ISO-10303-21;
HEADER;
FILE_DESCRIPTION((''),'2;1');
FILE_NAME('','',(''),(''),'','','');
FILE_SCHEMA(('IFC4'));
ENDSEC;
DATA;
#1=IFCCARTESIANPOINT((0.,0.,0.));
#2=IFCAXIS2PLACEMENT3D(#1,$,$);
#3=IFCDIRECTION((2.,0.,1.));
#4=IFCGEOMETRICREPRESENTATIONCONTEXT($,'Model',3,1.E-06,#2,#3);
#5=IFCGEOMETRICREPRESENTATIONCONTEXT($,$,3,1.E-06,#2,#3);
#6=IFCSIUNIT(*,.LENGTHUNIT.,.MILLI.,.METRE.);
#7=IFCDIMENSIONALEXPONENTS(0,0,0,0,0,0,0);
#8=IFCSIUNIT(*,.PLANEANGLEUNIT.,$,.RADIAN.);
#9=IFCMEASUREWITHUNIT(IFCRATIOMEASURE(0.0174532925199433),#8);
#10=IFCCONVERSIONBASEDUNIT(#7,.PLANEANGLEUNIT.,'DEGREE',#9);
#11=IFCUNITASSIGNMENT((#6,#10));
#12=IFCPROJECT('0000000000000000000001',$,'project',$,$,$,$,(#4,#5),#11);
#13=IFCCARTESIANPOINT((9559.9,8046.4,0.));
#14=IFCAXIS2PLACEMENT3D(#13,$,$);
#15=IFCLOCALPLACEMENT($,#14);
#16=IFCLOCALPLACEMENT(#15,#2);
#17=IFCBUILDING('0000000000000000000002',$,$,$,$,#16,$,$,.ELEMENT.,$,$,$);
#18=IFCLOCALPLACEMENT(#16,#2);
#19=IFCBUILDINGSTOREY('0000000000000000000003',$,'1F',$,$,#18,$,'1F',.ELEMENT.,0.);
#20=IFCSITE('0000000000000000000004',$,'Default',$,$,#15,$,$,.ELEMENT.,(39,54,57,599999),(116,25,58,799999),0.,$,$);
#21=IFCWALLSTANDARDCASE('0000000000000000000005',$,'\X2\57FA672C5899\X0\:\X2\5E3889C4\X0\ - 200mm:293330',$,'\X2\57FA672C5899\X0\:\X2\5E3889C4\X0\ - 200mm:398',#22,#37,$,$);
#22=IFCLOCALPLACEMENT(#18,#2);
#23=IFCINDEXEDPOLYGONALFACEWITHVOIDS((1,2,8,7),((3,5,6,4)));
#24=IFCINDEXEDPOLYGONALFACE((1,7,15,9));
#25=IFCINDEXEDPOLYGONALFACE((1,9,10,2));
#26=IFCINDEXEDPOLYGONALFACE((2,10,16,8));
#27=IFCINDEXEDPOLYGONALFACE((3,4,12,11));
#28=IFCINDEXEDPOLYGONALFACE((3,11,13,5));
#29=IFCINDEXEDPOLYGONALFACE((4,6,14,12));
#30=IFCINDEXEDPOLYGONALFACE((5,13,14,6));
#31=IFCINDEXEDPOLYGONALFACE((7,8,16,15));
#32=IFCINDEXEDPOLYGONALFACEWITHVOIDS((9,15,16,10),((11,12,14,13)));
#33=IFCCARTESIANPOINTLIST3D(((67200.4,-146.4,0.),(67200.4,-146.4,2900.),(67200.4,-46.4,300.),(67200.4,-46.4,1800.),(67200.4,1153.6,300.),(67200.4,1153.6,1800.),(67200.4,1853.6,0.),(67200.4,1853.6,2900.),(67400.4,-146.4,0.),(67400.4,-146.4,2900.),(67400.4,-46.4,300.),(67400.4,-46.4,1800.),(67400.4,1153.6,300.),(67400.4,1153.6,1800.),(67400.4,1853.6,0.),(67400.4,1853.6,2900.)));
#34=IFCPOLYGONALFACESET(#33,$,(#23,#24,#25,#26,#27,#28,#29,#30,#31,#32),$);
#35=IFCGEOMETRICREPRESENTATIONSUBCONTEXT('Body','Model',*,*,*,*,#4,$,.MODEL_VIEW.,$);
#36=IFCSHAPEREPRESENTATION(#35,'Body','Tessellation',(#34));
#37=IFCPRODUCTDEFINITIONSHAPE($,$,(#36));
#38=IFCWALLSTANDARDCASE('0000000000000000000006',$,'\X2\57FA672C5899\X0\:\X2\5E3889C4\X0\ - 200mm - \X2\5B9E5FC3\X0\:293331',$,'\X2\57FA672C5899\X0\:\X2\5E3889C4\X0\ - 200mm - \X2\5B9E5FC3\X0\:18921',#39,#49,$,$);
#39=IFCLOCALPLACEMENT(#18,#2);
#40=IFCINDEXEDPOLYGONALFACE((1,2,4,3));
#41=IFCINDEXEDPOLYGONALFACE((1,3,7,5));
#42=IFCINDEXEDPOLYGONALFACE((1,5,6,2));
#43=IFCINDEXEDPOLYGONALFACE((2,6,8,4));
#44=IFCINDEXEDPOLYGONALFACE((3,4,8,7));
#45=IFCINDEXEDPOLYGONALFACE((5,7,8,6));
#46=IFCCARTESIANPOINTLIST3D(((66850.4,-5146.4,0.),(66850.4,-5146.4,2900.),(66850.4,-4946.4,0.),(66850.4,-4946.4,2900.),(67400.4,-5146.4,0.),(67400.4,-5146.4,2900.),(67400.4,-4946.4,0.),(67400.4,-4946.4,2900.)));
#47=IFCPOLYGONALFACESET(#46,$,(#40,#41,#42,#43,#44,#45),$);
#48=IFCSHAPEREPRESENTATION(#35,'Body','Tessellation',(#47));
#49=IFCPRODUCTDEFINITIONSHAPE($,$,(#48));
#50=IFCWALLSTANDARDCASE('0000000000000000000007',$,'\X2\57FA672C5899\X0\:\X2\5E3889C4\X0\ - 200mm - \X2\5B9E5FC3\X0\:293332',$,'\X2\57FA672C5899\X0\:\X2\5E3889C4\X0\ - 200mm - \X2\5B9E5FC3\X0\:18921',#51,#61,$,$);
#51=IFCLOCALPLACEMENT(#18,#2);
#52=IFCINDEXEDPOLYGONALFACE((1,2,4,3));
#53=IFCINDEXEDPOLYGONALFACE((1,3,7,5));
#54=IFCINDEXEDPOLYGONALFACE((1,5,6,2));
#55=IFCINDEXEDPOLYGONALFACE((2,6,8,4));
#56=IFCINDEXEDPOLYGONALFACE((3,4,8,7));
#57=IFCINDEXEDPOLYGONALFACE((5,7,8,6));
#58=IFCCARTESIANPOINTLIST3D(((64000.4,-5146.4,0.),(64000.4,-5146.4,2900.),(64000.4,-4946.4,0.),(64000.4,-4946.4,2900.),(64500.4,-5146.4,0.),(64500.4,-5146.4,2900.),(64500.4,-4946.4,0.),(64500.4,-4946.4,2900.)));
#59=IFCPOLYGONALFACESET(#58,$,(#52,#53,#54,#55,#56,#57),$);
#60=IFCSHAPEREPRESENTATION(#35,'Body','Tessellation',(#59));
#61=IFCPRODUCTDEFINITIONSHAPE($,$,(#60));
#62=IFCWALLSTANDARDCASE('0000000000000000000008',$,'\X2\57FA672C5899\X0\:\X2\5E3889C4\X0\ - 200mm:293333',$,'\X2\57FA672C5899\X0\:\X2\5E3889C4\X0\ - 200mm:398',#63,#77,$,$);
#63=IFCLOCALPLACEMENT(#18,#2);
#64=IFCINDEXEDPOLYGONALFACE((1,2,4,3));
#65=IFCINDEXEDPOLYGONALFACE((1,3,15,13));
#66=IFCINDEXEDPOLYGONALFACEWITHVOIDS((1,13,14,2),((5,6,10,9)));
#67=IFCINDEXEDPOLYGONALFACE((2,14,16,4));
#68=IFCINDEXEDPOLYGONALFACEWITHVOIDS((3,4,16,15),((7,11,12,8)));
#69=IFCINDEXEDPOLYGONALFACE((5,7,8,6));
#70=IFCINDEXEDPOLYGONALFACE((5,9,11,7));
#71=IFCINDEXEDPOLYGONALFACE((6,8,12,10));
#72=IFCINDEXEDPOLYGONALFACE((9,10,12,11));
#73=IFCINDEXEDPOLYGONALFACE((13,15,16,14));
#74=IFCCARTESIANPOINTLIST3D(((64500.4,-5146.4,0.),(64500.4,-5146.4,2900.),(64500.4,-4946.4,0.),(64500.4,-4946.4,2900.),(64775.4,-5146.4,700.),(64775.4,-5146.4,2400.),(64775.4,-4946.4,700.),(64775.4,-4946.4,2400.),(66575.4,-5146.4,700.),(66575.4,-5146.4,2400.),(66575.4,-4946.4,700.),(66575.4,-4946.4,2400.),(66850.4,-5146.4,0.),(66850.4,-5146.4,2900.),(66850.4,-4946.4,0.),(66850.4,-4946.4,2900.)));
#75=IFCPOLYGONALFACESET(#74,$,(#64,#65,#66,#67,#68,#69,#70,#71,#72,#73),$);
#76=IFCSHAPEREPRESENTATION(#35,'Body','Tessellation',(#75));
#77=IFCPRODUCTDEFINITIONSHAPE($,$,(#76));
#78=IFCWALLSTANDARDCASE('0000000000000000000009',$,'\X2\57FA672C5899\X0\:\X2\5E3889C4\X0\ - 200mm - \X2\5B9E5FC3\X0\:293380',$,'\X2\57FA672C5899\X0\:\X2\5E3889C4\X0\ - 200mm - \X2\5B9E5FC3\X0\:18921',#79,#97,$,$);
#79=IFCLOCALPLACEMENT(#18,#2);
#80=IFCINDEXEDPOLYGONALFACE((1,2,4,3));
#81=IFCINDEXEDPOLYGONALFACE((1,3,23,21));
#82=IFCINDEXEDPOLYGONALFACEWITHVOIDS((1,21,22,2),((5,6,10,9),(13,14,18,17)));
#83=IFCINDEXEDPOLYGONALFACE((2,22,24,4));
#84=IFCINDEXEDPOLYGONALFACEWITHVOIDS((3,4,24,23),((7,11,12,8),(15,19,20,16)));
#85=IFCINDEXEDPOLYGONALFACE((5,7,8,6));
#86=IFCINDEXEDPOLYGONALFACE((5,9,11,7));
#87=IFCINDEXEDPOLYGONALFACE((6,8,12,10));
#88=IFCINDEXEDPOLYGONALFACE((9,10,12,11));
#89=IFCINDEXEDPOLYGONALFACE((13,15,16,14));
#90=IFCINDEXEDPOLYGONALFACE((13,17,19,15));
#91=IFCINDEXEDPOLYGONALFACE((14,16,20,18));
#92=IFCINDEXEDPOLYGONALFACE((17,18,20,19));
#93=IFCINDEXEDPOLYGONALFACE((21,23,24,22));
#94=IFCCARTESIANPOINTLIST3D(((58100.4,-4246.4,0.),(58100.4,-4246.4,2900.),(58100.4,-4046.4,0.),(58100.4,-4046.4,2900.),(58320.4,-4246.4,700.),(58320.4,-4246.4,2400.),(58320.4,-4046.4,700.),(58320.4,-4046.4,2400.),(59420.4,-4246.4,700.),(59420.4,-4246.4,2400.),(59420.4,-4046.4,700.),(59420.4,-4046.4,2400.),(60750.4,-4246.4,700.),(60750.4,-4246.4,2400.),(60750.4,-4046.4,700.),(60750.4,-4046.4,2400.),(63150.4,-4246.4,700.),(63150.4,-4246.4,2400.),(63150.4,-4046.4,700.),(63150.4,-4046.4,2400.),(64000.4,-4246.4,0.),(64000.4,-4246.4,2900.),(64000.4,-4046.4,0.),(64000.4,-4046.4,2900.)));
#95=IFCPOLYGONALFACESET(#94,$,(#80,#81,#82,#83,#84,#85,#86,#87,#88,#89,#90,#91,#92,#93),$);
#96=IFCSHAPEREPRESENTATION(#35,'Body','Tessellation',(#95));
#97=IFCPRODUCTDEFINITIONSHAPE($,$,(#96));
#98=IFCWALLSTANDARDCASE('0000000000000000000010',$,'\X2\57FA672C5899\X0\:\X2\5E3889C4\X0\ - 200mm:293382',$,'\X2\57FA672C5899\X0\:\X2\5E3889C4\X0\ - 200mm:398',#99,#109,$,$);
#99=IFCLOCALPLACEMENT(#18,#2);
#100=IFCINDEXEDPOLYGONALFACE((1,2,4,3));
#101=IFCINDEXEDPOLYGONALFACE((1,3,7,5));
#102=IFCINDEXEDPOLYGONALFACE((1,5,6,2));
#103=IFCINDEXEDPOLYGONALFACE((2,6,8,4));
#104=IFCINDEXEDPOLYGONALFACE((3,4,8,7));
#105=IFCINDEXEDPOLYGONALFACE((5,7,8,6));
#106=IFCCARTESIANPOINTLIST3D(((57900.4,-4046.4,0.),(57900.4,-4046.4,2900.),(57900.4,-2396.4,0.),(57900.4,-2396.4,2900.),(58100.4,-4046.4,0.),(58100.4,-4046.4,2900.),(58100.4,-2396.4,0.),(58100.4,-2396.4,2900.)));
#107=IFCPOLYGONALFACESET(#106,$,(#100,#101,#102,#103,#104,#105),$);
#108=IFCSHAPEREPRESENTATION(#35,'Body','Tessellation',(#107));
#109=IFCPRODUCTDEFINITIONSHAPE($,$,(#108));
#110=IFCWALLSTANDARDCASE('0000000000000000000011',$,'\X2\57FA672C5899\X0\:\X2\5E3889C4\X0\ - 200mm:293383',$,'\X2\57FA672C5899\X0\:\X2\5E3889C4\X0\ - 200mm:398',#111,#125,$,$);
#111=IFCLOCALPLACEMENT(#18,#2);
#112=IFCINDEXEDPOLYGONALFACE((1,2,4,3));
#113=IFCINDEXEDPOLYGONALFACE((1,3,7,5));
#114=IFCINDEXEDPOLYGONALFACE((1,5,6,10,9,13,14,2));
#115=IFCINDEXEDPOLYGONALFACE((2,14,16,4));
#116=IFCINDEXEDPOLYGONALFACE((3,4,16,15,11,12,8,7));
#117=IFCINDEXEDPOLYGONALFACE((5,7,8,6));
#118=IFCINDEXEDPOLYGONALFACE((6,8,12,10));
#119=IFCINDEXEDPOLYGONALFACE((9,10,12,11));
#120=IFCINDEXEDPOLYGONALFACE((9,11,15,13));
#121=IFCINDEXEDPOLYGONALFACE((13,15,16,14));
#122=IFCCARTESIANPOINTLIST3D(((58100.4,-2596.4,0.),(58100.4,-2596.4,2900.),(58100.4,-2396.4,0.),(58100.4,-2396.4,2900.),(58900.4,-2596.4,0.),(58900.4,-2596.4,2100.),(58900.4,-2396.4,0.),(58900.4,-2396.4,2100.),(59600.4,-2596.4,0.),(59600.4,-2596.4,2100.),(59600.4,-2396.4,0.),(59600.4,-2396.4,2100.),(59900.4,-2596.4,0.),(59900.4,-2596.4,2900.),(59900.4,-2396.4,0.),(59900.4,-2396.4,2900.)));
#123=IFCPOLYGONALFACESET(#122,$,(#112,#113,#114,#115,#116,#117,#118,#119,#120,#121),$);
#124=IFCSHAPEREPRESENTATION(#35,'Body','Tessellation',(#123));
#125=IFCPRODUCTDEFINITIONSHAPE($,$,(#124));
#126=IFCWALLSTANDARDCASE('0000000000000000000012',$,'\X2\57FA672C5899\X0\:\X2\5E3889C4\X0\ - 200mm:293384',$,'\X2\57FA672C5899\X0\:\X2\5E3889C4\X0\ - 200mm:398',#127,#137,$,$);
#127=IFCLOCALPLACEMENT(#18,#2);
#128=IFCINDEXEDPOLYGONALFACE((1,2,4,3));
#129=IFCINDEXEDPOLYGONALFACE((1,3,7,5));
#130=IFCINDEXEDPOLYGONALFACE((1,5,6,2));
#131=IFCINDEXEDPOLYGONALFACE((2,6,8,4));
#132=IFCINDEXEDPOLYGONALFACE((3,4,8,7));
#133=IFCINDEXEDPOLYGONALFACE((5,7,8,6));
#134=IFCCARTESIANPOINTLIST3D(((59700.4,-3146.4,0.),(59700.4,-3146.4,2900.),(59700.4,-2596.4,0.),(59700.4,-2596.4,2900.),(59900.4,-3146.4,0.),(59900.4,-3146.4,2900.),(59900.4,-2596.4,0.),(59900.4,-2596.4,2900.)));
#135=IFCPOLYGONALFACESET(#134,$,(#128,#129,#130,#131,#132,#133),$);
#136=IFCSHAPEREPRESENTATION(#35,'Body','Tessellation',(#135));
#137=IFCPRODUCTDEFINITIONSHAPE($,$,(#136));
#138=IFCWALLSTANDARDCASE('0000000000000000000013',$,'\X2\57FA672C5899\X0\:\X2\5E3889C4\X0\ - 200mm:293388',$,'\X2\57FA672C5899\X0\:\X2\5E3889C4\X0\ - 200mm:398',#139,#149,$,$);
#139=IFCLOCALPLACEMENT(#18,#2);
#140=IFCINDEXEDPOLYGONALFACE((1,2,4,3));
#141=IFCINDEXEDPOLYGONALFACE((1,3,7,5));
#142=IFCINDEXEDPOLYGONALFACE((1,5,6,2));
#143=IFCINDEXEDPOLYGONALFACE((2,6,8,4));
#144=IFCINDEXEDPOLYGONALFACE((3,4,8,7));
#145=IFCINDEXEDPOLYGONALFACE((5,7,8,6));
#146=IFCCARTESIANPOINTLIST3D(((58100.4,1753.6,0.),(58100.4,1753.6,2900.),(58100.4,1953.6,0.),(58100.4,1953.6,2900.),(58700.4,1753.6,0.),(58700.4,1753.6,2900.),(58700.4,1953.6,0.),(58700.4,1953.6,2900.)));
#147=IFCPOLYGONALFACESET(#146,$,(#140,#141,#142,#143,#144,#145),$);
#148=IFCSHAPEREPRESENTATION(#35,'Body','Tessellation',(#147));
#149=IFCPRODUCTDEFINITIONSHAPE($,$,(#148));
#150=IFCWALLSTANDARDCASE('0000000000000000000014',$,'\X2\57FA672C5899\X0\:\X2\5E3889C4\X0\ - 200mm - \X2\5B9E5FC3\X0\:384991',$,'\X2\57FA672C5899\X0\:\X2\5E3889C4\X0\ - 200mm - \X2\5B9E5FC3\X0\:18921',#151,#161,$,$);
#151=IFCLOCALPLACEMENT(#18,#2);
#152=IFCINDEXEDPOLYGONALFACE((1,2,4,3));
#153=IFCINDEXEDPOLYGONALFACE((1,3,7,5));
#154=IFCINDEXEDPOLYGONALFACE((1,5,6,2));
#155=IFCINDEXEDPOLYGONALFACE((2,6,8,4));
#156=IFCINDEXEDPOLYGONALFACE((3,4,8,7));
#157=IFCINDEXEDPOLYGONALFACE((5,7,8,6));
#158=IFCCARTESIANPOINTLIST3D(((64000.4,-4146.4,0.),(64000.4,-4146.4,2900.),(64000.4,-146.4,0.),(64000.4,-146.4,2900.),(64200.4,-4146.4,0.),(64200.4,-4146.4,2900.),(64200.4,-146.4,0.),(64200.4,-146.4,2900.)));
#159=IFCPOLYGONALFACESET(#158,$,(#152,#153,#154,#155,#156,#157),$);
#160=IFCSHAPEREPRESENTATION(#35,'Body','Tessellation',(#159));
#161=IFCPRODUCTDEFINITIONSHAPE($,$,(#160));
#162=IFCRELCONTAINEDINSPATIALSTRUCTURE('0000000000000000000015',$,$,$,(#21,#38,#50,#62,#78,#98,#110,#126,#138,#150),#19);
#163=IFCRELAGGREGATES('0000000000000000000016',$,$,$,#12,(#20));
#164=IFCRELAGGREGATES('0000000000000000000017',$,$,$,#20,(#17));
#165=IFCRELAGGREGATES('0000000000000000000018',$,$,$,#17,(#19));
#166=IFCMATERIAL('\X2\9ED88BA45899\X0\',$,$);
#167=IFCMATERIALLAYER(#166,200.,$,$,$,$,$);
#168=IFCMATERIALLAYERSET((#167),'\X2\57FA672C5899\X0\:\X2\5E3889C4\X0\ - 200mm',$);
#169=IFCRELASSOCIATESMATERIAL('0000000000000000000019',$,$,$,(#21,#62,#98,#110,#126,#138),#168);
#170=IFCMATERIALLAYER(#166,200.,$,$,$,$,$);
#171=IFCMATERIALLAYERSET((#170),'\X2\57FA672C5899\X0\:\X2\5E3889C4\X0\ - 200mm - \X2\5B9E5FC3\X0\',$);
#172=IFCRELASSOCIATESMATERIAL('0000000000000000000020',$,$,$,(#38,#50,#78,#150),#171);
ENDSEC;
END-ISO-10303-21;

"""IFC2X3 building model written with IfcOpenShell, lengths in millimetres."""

from ifc_helpers import new_model, entity, si_unit, converted_unit, direction, frame, frame_2d, origin, place, context, subcontext, project, spatial, rectangle, extrude, clip, halfspace, material, layer, layer_set, layer_usage, element, save


model = new_model("IFC2X3")

# Units and contexts
model_context = context("Model", 3, precision=1e-06, world=origin(), true_north=direction((2.0, 0.0, 1.0)))
context_of_model = context(None, 3, precision=1e-06, world=origin(), true_north=direction((2.0, 0.0, 1.0)))
body_context = subcontext(model_context, "Body", "Model", "MODEL_VIEW")
ifc_project = project(units=[si_unit("LENGTHUNIT", "METRE", prefix="MILLI"), converted_unit("PLANEANGLEUNIT", "DEGREE", entity("IfcRatioMeasure", 0.0174532925199433), si_unit("PLANEANGLEUNIT", "RADIAN"), dimensions=[0, 0, 0, 0, 0, 0, 0])], contexts=[model_context, context_of_model])

# Site, building, storey
site_placement = place(None, frame((9559.9, 8046.4, 0.0)))
site = spatial("IfcSite", under=ifc_project, at=site_placement, Name="Default", CompositionType="ELEMENT", RefLatitude=(39, 54, 57, 599999), RefLongitude=(116, 25, 58, 799999), RefElevation=0.0)
building_placement = place(site_placement, origin())
building = spatial("IfcBuilding", under=site, at=building_placement, CompositionType="ELEMENT")
storey_placement = place(building_placement, origin())
storey = spatial("IfcBuildingStorey", under=building, at=storey_placement, Name="1F", LongName="1F", CompositionType="ELEMENT", Elevation=0.0)

# Shared definitions
ifc_material = material(Name="默认墙")
ifc_layer_1 = layer(ifc_material, 200.0)
ifc_layer_set_1 = layer_set([ifc_layer_1], Name="基本墙:常规 - 200mm - 实心")
ifc_layer_2 = layer(ifc_material, 200.0)
ifc_layer_set_2 = layer_set([ifc_layer_2], Name="基本墙:常规 - 200mm")

# Wall, opening
ifc_layer_usage_1 = layer_usage(ifc_layer_set_2, "AXIS2", "NEGATIVE", 100.0)
wall_1_placement = place(storey_placement, frame((67300.4, 1853.6, 0.0), z_axis=(0.0, 0.0, 1.0), x_axis=(0.0, -1.0, 0.0)))
wall_1 = element("IfcWallStandardCase", 1, at=wall_1_placement, inside=storey, material=ifc_layer_usage_1, Name="基本墙:常规 - 200mm:293330", ObjectType="基本墙:常规 - 200mm:398", context=body_context, shape_type="Clipping", body=[
    clip(extrude(rectangle(XDim=2000.0, YDim=200.0, at=frame_2d((1000.0, 0.0), x_axis=(-1.0, 0.0))), origin(), (0.0, 0.0, 1.0), 2900.0), halfspace(frame((0.0, 0.0, -1400.0)), True)),
])
opening_1_placement = place(wall_1_placement, frame((700.0, -100.0, 300.0)))
element("IfcOpeningElement", 2, at=opening_1_placement, cuts=wall_1, ObjectType="Opening", context=body_context, shape_type="SweptSolid", body=[
    extrude(rectangle(XDim=1500.0, YDim=1200.0, at=frame_2d((750.0, 600.0), x_axis=(1.0, 0.0))), frame((0.0, 0.0, 0.0), z_axis=(0.0, 1.0, 0.0), x_axis=(0.0, 0.0, 1.0)), (0.0, 0.0, 1.0), 200.0),
])

# Walls
ifc_layer_usage_2 = layer_usage(ifc_layer_set_1, "AXIS2", "NEGATIVE", 100.0)
wall_2_placement = place(storey_placement, frame((67400.4, -5046.4, 0.0), z_axis=(0.0, 0.0, 1.0), x_axis=(-1.0, 0.0, 0.0)))
element("IfcWallStandardCase", 3, at=wall_2_placement, inside=storey, material=ifc_layer_usage_2, Name="基本墙:常规 - 200mm - 实心:293331", ObjectType="基本墙:常规 - 200mm - 实心:18921", context=body_context, shape_type="Clipping", body=[
    clip(extrude(rectangle(XDim=550.0, YDim=200.0, at=frame_2d((275.0, 0.0), x_axis=(-1.0, 0.0))), origin(), (0.0, 0.0, 1.0), 2900.0), halfspace(frame((0.0, 0.0, -1400.0)), True)),
])
ifc_layer_usage_3 = layer_usage(ifc_layer_set_1, "AXIS2", "NEGATIVE", 100.0)
wall_3_placement = place(storey_placement, frame((64000.4, -5046.4, 0.0)))
element("IfcWallStandardCase", 4, at=wall_3_placement, inside=storey, material=ifc_layer_usage_3, Name="基本墙:常规 - 200mm - 实心:293332", ObjectType="基本墙:常规 - 200mm - 实心:18921", context=body_context, shape_type="Clipping", body=[
    clip(extrude(rectangle(XDim=500.0, YDim=200.0, at=frame_2d((250.0, 0.0), x_axis=(-1.0, 0.0))), origin(), (0.0, 0.0, 1.0), 2900.0), halfspace(frame((0.0, 0.0, -1400.0)), True)),
])

# Wall, opening
ifc_layer_usage_4 = layer_usage(ifc_layer_set_2, "AXIS2", "NEGATIVE", 100.0)
wall_4_placement = place(storey_placement, frame((64500.4, -5046.4, 0.0)))
wall_4 = element("IfcWallStandardCase", 5, at=wall_4_placement, inside=storey, material=ifc_layer_usage_4, Name="基本墙:常规 - 200mm:293333", ObjectType="基本墙:常规 - 200mm:398", context=body_context, shape_type="Clipping", body=[
    clip(extrude(rectangle(XDim=2350.0, YDim=200.0, at=frame_2d((1175.0, 0.0), x_axis=(-1.0, 0.0))), origin(), (0.0, 0.0, 1.0), 2900.0), halfspace(frame((0.0, 0.0, -1400.0)), True)),
])
opening_2_placement = place(wall_4_placement, frame((275.0, -100.0, 700.0)))
element("IfcOpeningElement", 6, at=opening_2_placement, cuts=wall_4, ObjectType="Opening", context=body_context, shape_type="SweptSolid", body=[
    extrude(rectangle(XDim=1700.0, YDim=1800.0, at=frame_2d((850.0, 900.0), x_axis=(1.0, 0.0))), frame((0.0, 0.0, 0.0), z_axis=(0.0, 1.0, 0.0), x_axis=(0.0, 0.0, 1.0)), (0.0, 0.0, 1.0), 200.0),
])

# Wall, openings
ifc_layer_usage_5 = layer_usage(ifc_layer_set_1, "AXIS2", "NEGATIVE", 100.0)
wall_5_placement = place(storey_placement, frame((64000.4, -4146.4, 0.0), z_axis=(0.0, 0.0, 1.0), x_axis=(-1.0, 0.0, 0.0)))
wall_5 = element("IfcWallStandardCase", 7, at=wall_5_placement, inside=storey, material=ifc_layer_usage_5, Name="基本墙:常规 - 200mm - 实心:293380", ObjectType="基本墙:常规 - 200mm - 实心:18921", context=body_context, shape_type="Clipping", body=[
    clip(extrude(rectangle(XDim=5900.0, YDim=200.0, at=frame_2d((2950.0, 0.0), x_axis=(-1.0, 0.0))), origin(), (0.0, 0.0, 1.0), 2900.0), halfspace(frame((0.0, 0.0, -1400.0)), True)),
])
opening_3_placement = place(wall_5_placement, frame((850.0, -100.0, 700.0)))
element("IfcOpeningElement", 8, at=opening_3_placement, cuts=wall_5, ObjectType="Opening", context=body_context, shape_type="SweptSolid", body=[
    extrude(rectangle(XDim=1700.0, YDim=2400.0, at=frame_2d((850.0, 1200.0), x_axis=(1.0, 0.0))), frame((0.0, 0.0, 0.0), z_axis=(0.0, 1.0, 0.0), x_axis=(0.0, 0.0, 1.0)), (0.0, 0.0, 1.0), 200.0),
])
opening_4_placement = place(wall_5_placement, frame((5680.0, 100.0, 700.0)))
element("IfcOpeningElement", 9, at=opening_4_placement, cuts=wall_5, ObjectType="Opening", context=body_context, shape_type="SweptSolid", body=[
    extrude(rectangle(XDim=1700.0, YDim=1100.0, at=frame_2d((850.0, 550.0), x_axis=(1.0, 0.0))), frame((0.0, 0.0, 0.0), z_axis=(0.0, -1.0, 0.0), x_axis=(0.0, 0.0, 1.0)), (0.0, 0.0, 1.0), 200.0),
])

# Wall
ifc_layer_usage_6 = layer_usage(ifc_layer_set_2, "AXIS2", "NEGATIVE", 100.0)
wall_6_placement = place(storey_placement, frame((58000.4, -4046.4, 0.0), z_axis=(0.0, 0.0, 1.0), x_axis=(0.0, 1.0, 0.0)))
element("IfcWallStandardCase", 10, at=wall_6_placement, inside=storey, material=ifc_layer_usage_6, Name="基本墙:常规 - 200mm:293382", ObjectType="基本墙:常规 - 200mm:398", context=body_context, shape_type="Clipping", body=[
    clip(extrude(rectangle(XDim=1650.0, YDim=200.0, at=frame_2d((825.0, 0.0), x_axis=(-1.0, 0.0))), origin(), (0.0, 0.0, 1.0), 2900.0), halfspace(frame((0.0, 0.0, -1400.0)), True)),
])

# Wall, opening
ifc_layer_usage_7 = layer_usage(ifc_layer_set_2, "AXIS2", "NEGATIVE", 100.0)
wall_7_placement = place(storey_placement, frame((58100.4, -2496.4, 0.0)))
wall_7 = element("IfcWallStandardCase", 11, at=wall_7_placement, inside=storey, material=ifc_layer_usage_7, Name="基本墙:常规 - 200mm:293383", ObjectType="基本墙:常规 - 200mm:398", context=body_context, shape_type="Clipping", body=[
    clip(extrude(rectangle(XDim=1800.0, YDim=200.0, at=frame_2d((900.0, 0.0), x_axis=(-1.0, 0.0))), origin(), (0.0, 0.0, 1.0), 2900.0), halfspace(frame((0.0, 0.0, -1400.0)), True)),
])
opening_5_placement = place(wall_7_placement, frame((1500.0, 100.0, 0.0)))
element("IfcOpeningElement", 12, at=opening_5_placement, cuts=wall_7, ObjectType="Opening", context=body_context, shape_type="SweptSolid", body=[
    extrude(rectangle(XDim=2100.0, YDim=700.0, at=frame_2d((1050.0, 350.0), x_axis=(1.0, 0.0))), frame((0.0, 0.0, 0.0), z_axis=(0.0, -1.0, 0.0), x_axis=(0.0, 0.0, 1.0)), (0.0, 0.0, 1.0), 200.0),
])

# Walls
ifc_layer_usage_8 = layer_usage(ifc_layer_set_2, "AXIS2", "NEGATIVE", 100.0)
wall_8_placement = place(storey_placement, frame((59800.4, -2596.4, 0.0), z_axis=(0.0, 0.0, 1.0), x_axis=(0.0, -1.0, 0.0)))
element("IfcWallStandardCase", 13, at=wall_8_placement, inside=storey, material=ifc_layer_usage_8, Name="基本墙:常规 - 200mm:293384", ObjectType="基本墙:常规 - 200mm:398", context=body_context, shape_type="Clipping", body=[
    clip(extrude(rectangle(XDim=550.0, YDim=200.0, at=frame_2d((275.0, 0.0), x_axis=(-1.0, 0.0))), origin(), (0.0, 0.0, 1.0), 2900.0), halfspace(frame((0.0, 0.0, -1400.0)), True)),
])
ifc_layer_usage_9 = layer_usage(ifc_layer_set_2, "AXIS2", "NEGATIVE", 100.0)
wall_9_placement = place(storey_placement, frame((58100.4, 1853.6, 0.0)))
element("IfcWallStandardCase", 14, at=wall_9_placement, inside=storey, material=ifc_layer_usage_9, Name="基本墙:常规 - 200mm:293388", ObjectType="基本墙:常规 - 200mm:398", context=body_context, shape_type="Clipping", body=[
    clip(extrude(rectangle(XDim=600.0, YDim=200.0, at=frame_2d((300.0, 0.0), x_axis=(-1.0, 0.0))), origin(), (0.0, 0.0, 1.0), 2900.0), halfspace(frame((0.0, 0.0, -1400.0)), True)),
])
ifc_layer_usage_10 = layer_usage(ifc_layer_set_1, "AXIS2", "NEGATIVE", 100.0)
wall_10_placement = place(storey_placement, frame((64100.4, -4146.4, 0.0), z_axis=(0.0, 0.0, 1.0), x_axis=(0.0, 1.0, 0.0)))
element("IfcWallStandardCase", 15, at=wall_10_placement, inside=storey, material=ifc_layer_usage_10, Name="基本墙:常规 - 200mm - 实心:384991", ObjectType="基本墙:常规 - 200mm - 实心:18921", context=body_context, shape_type="Clipping", body=[
    clip(extrude(rectangle(XDim=4000.0, YDim=200.0, at=frame_2d((2000.0, 0.0), x_axis=(-1.0, 0.0))), origin(), (0.0, 0.0, 1.0), 2900.0), halfspace(frame((0.0, 0.0, -1400.0)), True)),
])

save(model, "model.ifc")
